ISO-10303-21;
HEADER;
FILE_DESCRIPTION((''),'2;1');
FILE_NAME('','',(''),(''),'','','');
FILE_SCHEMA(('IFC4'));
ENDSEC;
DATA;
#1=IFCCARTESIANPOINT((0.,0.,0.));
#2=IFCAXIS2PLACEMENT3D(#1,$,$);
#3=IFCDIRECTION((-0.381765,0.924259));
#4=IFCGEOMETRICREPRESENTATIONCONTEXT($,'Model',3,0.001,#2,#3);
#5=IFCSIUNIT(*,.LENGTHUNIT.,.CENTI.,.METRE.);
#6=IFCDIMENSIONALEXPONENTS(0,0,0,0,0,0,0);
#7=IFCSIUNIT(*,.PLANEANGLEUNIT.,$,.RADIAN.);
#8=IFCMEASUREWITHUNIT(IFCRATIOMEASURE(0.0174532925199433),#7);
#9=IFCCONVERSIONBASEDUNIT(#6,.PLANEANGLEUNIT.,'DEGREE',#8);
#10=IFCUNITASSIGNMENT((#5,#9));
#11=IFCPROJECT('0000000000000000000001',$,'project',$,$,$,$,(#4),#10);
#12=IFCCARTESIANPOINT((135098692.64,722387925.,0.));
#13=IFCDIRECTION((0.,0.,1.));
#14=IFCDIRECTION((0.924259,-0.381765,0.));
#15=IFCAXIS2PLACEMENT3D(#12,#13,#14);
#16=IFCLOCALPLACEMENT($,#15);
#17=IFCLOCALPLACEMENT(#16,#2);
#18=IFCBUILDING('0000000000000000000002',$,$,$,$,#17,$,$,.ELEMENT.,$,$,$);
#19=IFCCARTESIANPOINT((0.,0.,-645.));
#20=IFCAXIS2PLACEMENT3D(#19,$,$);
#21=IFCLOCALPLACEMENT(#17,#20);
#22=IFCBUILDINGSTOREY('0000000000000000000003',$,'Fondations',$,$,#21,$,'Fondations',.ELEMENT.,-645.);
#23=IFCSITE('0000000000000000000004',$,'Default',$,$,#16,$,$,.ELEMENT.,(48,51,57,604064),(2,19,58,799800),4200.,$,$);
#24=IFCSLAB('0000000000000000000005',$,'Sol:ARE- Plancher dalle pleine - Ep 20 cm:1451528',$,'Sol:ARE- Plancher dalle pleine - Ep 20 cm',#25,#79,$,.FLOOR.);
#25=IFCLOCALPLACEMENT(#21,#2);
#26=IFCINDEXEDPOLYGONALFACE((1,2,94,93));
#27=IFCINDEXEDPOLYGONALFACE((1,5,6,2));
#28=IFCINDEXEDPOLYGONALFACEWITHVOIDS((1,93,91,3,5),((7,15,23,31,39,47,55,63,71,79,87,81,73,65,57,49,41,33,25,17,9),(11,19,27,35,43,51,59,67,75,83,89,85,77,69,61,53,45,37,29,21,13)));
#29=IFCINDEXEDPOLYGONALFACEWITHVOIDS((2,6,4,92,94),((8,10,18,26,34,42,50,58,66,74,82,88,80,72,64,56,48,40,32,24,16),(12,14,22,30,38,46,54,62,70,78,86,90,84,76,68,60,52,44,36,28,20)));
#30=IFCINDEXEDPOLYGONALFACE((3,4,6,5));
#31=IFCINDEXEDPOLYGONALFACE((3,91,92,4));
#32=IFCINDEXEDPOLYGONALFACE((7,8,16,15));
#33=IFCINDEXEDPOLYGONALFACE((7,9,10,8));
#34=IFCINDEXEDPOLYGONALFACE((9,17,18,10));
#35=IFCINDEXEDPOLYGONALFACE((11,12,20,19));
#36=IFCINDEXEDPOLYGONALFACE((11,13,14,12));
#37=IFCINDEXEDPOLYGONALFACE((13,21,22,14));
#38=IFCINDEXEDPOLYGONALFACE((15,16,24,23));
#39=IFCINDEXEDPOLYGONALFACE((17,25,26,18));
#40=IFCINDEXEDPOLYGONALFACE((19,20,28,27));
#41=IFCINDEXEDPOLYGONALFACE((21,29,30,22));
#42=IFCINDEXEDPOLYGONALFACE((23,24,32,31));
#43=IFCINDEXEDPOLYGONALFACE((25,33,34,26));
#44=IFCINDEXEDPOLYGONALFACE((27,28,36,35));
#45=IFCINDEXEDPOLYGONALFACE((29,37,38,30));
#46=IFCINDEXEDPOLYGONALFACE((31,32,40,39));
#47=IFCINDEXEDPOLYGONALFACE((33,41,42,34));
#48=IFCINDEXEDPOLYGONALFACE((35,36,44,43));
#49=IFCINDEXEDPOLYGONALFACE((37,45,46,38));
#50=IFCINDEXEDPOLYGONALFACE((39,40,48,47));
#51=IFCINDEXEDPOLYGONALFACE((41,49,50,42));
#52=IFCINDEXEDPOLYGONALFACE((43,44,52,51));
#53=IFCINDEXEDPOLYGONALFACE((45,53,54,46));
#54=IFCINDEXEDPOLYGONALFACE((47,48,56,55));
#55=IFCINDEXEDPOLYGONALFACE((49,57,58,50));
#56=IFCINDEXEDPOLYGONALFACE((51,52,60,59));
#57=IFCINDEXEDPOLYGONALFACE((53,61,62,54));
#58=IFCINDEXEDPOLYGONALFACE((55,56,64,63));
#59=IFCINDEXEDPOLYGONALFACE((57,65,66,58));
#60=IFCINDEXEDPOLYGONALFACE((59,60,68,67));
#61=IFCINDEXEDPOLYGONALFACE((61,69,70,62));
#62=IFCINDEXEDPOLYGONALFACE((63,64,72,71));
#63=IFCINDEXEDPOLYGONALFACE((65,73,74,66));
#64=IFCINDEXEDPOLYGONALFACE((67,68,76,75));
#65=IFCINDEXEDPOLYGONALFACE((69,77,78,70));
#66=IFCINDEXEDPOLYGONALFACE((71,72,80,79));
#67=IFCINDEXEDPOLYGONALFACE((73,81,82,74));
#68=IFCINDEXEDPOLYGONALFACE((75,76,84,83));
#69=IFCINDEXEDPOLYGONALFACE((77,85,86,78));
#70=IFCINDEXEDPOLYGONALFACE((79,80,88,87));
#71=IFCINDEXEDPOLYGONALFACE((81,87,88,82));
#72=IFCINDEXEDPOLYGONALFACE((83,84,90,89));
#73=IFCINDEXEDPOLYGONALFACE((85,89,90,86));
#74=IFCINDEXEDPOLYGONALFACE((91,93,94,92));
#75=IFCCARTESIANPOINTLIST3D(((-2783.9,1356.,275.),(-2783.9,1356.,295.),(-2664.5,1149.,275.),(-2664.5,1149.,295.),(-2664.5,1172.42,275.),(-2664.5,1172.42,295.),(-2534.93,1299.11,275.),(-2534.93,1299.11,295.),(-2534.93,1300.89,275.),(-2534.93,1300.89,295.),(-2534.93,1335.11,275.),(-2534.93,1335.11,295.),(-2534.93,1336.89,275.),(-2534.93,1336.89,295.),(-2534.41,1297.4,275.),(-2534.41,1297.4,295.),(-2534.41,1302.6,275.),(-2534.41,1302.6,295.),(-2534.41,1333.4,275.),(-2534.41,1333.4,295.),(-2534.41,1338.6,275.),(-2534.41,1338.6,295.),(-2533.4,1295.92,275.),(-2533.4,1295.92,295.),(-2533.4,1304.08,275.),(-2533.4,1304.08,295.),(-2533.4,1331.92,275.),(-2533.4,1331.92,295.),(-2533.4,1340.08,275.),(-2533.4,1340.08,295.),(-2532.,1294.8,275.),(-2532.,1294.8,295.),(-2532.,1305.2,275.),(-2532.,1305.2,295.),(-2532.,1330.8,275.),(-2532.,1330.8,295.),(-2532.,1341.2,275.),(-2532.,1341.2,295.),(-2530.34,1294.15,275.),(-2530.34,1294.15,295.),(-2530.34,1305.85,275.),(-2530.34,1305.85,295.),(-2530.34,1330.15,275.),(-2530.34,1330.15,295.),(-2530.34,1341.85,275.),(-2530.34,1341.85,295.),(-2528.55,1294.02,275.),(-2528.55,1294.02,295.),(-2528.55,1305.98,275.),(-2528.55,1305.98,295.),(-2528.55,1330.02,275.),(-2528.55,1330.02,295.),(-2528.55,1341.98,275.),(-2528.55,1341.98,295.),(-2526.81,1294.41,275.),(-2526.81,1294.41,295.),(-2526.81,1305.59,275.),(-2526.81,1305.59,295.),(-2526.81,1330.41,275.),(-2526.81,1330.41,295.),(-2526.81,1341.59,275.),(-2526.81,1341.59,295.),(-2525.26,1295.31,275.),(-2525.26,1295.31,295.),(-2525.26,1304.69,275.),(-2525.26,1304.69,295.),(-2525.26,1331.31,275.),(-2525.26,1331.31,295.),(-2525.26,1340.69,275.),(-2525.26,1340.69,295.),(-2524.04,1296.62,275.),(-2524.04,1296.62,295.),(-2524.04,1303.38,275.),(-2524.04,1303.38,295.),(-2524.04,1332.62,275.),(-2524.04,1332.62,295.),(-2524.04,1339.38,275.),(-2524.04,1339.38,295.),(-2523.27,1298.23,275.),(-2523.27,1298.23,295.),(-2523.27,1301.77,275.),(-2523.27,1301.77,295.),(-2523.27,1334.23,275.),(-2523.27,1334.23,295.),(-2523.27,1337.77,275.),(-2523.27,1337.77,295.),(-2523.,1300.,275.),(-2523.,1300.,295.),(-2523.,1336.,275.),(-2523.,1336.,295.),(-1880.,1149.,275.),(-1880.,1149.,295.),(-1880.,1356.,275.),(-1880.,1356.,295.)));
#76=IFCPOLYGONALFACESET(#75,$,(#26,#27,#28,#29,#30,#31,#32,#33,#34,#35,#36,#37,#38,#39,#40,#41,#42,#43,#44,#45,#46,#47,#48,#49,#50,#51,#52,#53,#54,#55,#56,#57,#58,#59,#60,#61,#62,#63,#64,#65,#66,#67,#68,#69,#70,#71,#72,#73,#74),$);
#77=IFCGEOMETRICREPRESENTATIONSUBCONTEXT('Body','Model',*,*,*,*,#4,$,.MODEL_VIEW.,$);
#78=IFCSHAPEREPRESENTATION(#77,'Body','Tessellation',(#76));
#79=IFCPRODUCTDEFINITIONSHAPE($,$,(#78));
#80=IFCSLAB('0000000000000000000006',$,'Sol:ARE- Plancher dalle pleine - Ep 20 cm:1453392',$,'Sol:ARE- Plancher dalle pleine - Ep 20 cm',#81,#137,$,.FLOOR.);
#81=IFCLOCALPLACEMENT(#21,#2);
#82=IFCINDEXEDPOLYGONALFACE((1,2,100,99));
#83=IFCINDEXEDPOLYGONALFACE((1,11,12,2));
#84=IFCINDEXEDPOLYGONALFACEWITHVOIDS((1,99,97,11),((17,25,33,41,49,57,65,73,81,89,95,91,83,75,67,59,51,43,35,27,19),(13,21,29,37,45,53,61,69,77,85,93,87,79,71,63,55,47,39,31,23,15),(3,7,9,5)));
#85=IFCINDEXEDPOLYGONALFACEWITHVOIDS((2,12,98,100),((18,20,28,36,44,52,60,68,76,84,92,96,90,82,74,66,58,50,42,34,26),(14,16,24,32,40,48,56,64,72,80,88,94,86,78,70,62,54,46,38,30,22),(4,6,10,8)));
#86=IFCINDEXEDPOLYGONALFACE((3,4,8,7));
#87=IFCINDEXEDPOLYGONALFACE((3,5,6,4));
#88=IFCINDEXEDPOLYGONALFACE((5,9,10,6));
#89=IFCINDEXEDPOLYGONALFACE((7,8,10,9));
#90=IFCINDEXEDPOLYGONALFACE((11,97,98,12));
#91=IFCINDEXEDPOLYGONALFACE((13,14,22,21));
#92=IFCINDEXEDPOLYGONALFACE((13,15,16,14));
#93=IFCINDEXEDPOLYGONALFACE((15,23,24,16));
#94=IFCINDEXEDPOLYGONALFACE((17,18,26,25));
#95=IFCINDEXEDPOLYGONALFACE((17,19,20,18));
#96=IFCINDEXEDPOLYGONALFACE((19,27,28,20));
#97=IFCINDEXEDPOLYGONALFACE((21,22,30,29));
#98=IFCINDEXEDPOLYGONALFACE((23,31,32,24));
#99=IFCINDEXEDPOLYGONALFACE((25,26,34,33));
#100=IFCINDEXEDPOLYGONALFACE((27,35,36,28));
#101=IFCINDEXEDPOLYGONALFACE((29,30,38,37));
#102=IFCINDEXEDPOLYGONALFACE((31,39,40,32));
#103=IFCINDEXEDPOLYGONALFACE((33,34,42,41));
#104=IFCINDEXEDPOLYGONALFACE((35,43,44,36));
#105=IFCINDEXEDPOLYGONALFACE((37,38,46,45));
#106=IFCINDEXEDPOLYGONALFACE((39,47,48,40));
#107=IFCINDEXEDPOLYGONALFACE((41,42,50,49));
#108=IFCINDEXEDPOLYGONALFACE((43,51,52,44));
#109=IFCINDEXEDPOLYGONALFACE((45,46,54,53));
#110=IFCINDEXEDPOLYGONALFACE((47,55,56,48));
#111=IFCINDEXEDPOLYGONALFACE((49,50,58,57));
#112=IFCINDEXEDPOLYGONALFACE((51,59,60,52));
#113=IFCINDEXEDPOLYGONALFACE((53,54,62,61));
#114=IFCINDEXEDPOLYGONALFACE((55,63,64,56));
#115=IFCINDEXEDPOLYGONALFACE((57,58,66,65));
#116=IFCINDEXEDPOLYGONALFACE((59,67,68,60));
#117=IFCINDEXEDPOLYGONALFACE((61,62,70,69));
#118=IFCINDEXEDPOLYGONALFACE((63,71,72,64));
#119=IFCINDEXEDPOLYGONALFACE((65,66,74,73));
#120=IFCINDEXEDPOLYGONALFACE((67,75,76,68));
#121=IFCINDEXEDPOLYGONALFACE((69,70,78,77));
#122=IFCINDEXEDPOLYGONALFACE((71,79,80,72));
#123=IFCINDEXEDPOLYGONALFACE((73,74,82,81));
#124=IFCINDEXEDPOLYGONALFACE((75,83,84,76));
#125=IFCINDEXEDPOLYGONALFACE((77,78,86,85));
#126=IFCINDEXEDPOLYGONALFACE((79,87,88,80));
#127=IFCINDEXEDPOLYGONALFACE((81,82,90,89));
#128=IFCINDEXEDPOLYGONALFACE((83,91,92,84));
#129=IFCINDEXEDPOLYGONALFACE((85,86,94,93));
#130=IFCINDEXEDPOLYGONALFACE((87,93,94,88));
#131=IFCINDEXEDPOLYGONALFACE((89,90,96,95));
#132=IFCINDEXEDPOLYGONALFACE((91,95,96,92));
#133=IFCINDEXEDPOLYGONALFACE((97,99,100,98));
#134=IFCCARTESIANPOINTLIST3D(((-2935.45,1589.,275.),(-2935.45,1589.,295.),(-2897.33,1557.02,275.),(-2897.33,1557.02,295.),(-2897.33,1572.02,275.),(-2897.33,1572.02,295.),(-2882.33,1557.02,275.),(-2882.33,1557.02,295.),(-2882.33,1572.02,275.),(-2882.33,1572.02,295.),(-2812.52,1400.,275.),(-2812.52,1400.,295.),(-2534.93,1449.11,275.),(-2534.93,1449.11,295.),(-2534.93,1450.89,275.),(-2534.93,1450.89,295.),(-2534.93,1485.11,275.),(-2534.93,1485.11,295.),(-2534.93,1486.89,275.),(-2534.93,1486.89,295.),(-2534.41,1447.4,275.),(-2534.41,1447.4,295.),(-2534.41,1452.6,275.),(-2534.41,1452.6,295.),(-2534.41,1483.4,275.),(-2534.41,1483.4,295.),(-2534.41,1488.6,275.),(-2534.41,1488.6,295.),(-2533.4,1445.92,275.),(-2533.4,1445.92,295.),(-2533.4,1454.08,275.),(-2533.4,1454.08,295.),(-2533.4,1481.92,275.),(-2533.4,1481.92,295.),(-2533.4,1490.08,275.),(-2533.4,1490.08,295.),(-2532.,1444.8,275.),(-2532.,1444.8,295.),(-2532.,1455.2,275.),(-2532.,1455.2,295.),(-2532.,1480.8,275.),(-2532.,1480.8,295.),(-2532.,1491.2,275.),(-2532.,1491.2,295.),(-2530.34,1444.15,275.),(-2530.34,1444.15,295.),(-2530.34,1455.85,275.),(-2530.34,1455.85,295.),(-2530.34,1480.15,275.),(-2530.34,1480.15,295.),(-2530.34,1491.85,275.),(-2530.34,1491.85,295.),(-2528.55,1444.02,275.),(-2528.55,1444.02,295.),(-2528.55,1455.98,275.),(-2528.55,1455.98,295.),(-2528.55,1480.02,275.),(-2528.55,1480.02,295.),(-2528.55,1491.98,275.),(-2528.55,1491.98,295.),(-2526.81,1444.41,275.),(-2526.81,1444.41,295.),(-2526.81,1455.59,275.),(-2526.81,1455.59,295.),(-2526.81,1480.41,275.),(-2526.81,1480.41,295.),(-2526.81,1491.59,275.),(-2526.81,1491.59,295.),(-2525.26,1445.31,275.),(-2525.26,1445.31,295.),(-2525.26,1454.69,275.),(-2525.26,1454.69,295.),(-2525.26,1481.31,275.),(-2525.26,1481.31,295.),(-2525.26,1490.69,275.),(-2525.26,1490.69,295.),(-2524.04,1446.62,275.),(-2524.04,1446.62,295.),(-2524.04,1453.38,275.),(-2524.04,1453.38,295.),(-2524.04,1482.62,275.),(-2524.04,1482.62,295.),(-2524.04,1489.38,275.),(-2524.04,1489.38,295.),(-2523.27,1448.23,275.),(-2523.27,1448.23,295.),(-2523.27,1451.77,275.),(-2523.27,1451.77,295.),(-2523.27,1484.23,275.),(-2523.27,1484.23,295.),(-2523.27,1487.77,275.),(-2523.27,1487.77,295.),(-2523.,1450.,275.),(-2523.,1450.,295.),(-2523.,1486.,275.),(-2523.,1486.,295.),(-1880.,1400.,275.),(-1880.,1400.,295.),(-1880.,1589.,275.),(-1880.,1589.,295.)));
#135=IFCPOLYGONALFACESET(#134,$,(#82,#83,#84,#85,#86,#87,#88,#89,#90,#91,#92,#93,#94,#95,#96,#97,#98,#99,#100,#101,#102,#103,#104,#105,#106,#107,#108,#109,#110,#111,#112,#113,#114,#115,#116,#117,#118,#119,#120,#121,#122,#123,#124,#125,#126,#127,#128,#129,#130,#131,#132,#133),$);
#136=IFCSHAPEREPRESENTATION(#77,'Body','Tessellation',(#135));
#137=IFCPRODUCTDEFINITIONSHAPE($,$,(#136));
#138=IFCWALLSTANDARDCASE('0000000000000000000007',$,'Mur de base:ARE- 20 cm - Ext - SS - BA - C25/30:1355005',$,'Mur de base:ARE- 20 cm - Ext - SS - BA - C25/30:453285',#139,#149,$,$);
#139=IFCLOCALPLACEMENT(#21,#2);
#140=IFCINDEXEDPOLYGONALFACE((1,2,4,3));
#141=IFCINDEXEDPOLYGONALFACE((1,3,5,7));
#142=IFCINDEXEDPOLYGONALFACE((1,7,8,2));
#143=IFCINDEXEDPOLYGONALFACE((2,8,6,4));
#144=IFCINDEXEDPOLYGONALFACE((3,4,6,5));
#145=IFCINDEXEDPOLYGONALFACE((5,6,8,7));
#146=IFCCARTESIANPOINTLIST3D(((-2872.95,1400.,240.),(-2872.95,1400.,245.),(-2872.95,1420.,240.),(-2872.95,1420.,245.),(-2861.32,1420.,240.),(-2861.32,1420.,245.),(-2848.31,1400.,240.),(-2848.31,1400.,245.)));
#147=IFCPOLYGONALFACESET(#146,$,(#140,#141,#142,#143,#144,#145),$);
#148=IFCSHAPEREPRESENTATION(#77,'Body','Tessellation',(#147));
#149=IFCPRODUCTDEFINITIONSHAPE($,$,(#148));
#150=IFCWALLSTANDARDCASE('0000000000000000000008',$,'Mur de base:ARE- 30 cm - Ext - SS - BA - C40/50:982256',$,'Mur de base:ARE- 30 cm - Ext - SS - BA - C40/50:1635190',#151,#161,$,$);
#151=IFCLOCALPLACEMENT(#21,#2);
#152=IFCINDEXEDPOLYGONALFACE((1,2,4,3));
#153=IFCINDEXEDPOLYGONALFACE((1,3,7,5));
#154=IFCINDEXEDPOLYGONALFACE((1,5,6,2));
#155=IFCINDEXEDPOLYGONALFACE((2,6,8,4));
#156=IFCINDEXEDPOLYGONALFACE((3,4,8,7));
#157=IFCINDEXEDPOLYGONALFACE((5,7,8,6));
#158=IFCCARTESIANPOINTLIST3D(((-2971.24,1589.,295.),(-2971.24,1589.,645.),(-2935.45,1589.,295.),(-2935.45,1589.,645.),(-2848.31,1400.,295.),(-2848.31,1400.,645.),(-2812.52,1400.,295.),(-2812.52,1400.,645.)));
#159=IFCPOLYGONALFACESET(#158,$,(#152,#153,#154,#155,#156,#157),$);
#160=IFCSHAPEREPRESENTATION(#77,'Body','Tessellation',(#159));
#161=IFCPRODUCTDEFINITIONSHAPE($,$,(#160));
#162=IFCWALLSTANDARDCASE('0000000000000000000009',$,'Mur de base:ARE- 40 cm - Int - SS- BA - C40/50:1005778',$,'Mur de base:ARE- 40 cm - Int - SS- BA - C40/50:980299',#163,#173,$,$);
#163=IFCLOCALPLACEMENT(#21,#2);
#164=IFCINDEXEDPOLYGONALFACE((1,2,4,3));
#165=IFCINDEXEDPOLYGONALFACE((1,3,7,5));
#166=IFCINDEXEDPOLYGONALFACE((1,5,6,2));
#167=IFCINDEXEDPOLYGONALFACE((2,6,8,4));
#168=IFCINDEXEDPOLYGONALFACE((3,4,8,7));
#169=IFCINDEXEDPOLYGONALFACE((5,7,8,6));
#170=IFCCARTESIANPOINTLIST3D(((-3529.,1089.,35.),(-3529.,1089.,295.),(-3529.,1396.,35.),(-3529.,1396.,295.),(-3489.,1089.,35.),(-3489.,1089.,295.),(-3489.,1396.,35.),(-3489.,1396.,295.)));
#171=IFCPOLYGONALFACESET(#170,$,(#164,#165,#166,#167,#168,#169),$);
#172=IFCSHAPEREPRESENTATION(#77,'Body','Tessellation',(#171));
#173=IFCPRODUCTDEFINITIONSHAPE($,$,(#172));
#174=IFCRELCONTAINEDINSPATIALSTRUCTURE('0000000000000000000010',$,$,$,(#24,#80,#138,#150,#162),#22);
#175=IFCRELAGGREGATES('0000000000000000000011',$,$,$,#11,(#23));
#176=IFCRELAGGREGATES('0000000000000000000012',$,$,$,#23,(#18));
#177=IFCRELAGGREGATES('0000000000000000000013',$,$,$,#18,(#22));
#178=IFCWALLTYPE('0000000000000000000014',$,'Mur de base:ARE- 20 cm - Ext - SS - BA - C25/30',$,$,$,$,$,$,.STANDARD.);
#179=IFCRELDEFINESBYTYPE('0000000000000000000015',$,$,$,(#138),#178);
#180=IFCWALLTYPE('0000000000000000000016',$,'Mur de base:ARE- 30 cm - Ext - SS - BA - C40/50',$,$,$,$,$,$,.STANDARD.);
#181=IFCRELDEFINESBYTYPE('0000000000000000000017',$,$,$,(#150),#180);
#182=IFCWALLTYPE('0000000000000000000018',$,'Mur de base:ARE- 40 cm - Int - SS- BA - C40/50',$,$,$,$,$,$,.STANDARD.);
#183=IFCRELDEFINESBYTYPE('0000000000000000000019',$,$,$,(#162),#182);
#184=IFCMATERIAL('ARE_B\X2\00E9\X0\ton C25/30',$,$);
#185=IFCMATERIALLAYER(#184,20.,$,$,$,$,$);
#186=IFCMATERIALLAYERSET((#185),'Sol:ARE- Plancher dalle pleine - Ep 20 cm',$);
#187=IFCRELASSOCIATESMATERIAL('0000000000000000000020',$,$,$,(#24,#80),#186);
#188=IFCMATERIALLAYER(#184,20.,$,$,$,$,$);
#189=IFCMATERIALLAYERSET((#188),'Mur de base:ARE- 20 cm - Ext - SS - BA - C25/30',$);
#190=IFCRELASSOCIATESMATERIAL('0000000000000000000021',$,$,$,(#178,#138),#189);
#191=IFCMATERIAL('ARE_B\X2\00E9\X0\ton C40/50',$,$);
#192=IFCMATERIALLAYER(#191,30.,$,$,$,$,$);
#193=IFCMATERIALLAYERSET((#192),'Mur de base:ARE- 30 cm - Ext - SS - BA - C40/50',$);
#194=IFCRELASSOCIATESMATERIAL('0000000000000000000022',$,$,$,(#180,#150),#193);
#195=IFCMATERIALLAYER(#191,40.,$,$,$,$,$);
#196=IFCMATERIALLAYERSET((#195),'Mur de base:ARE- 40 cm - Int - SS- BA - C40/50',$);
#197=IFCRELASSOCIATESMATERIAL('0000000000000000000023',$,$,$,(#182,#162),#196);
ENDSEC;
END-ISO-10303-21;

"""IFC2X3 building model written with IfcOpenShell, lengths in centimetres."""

from ifc_helpers import new_model, entity, si_unit, converted_unit, direction, frame, frame_2d, origin, origin_2d_with_axis, place, context, subcontext, project, spatial, polyline, rectangle, circle, outline, extrude, material, layer, layer_set, layer_usage, type_object, element, save


model = new_model("IFC2X3")

# Units and contexts
model_context = context("Model", 3, precision=0.001, world=origin(), true_north=direction((-0.381765, 0.924259)))
body_context = subcontext(model_context, "Body", "Model", "MODEL_VIEW")
ifc_project = project(units=[si_unit("LENGTHUNIT", "METRE", prefix="CENTI"), converted_unit("PLANEANGLEUNIT", "DEGREE", entity("IfcRatioMeasure", 0.0174532925199433), si_unit("PLANEANGLEUNIT", "RADIAN"), dimensions=[0, 0, 0, 0, 0, 0, 0])], contexts=[model_context])

# Site, building, storey
site_placement = place(None, frame((135098692.64, 722387925.0, 0.0), z_axis=(0.0, 0.0, 1.0), x_axis=(0.924259, -0.381765, 0.0)))
site = spatial("IfcSite", under=ifc_project, at=site_placement, Name="Default", CompositionType="ELEMENT", RefLatitude=(48, 51, 57, 604064), RefLongitude=(2, 19, 58, 799800), RefElevation=4200.0)
building_placement = place(site_placement, origin())
building = spatial("IfcBuilding", under=site, at=building_placement, CompositionType="ELEMENT")
storey_placement = place(building_placement, frame((0.0, 0.0, -645.0)))
storey = spatial("IfcBuildingStorey", under=building, at=storey_placement, Name="Fondations", LongName="Fondations", CompositionType="ELEMENT", Elevation=-645.0)

# Slabs, openings
ifc_material_1 = material(Name="ARE_Béton C25/30")
ifc_layer_1 = layer(ifc_material_1, 20.0)
ifc_layer_set_1 = layer_set([ifc_layer_1], Name="Sol:ARE- Plancher dalle pleine - Ep 20 cm")
ifc_layer_usage_1 = layer_usage(ifc_layer_set_1, "AXIS3", "POSITIVE", 0.0)
slab_1_placement = place(storey_placement, frame((-2783.9, 1149.0, 275.0)))
slab_1 = element("IfcSlab", 1, at=slab_1_placement, inside=storey, material=ifc_layer_usage_1, Name="Sol:ARE- Plancher dalle pleine - Ep 20 cm:1451528", ObjectType="Sol:ARE- Plancher dalle pleine - Ep 20 cm", PredefinedType="FLOOR", context=body_context, shape_type="SweptSolid", body=[
    extrude(outline(polyline([(-451.95, -103.5), (332.55, -103.5), (332.55, -80.08), (451.95, 103.5), (-451.95, 103.5), (-451.95, -103.5)])), frame((451.95, 103.5, 20.0), z_axis=(0.0, 0.0, -1.0), x_axis=(-1.0, 0.0, 0.0)), (0.0, 0.0, 1.0), 20.0),
])
opening_1_placement = place(slab_1_placement, origin())
element("IfcOpeningElement", 2, at=opening_1_placement, cuts=slab_1, ObjectType="Opening", context=body_context, shape_type="SweptSolid", body=[
    extrude(circle(Radius=6.0, at=origin_2d_with_axis()), frame((254.9, 187.0, 0.0)), (0.0, 0.0, 1.0), 20.0),
])
opening_2_placement = place(slab_1_placement, origin())
element("IfcOpeningElement", 3, at=opening_2_placement, cuts=slab_1, ObjectType="Opening", context=body_context, shape_type="SweptSolid", body=[
    extrude(circle(Radius=6.0, at=origin_2d_with_axis()), frame((254.9, 151.0, 0.0)), (0.0, 0.0, 1.0), 20.0),
])
ifc_layer_usage_2 = layer_usage(ifc_layer_set_1, "AXIS3", "POSITIVE", 0.0)
slab_2_placement = place(storey_placement, frame((-2935.45, 1400.0, 275.0)))
slab_2 = element("IfcSlab", 4, at=slab_2_placement, inside=storey, material=ifc_layer_usage_2, Name="Sol:ARE- Plancher dalle pleine - Ep 20 cm:1453392", ObjectType="Sol:ARE- Plancher dalle pleine - Ep 20 cm", PredefinedType="FLOOR", context=body_context, shape_type="SweptSolid", body=[
    extrude(outline(polyline([(-527.72, -94.5), (404.8, -94.5), (527.72, 94.5), (-527.72, 94.5), (-527.72, -94.5)])), frame((527.72, 94.5, 20.0), z_axis=(0.0, 0.0, -1.0), x_axis=(-1.0, 0.0, 0.0)), (0.0, 0.0, 1.0), 20.0),
])
opening_3_placement = place(slab_2_placement, origin())
element("IfcOpeningElement", 5, at=opening_3_placement, cuts=slab_2, ObjectType="Opening", context=body_context, shape_type="SweptSolid", body=[
    extrude(rectangle(XDim=15.0, YDim=15.0, at=origin_2d_with_axis()), frame((45.62, 164.52, -5.0), z_axis=(0.0, 0.0, 1.0), x_axis=(-1.0, 0.0, 0.0)), (0.0, 0.0, 1.0), 25.0),
])
opening_4_placement = place(slab_2_placement, origin())
element("IfcOpeningElement", 6, at=opening_4_placement, cuts=slab_2, ObjectType="Opening", context=body_context, shape_type="SweptSolid", body=[
    extrude(circle(Radius=6.0, at=origin_2d_with_axis()), frame((406.45, 50.0, 0.0)), (0.0, 0.0, 1.0), 20.0),
])
opening_5_placement = place(slab_2_placement, origin())
element("IfcOpeningElement", 7, at=opening_5_placement, cuts=slab_2, ObjectType="Opening", context=body_context, shape_type="SweptSolid", body=[
    extrude(circle(Radius=6.0, at=origin_2d_with_axis()), frame((406.45, 86.0, 0.0)), (0.0, 0.0, 1.0), 20.0),
])

# Walls
ifc_layer_2 = layer(ifc_material_1, 20.0)
ifc_layer_set_2 = layer_set([ifc_layer_2], Name="Mur de base:ARE- 20 cm - Ext - SS - BA - C25/30")
ifc_layer_usage_3 = layer_usage(ifc_layer_set_2, "AXIS2", "NEGATIVE", 10.0)
wall_type_1 = type_object("IfcWallType", Name="Mur de base:ARE- 20 cm - Ext - SS - BA - C25/30", PredefinedType="STANDARD", material=ifc_layer_set_2)
wall_1_placement = place(storey_placement, frame((-2872.95, 1410.0, 240.0)))
element("IfcWallStandardCase", 8, at=wall_1_placement, inside=storey, type_object=wall_type_1, material=ifc_layer_usage_3, Name="Mur de base:ARE- 20 cm - Ext - SS - BA - C25/30:1355005", ObjectType="Mur de base:ARE- 20 cm - Ext - SS - BA - C25/30:453285", context=body_context, shape_type="SweptSolid", body=[
    extrude(outline(polyline([(24.65, -10.0), (11.64, 10.0), (0.0, 10.0), (0.0, -10.0), (24.65, -10.0)])), origin(), (0.0, 0.0, 1.0), 5.0),
])
ifc_material_2 = material(Name="ARE_Béton C40/50")
ifc_layer_3 = layer(ifc_material_2, 30.0)
ifc_layer_set_3 = layer_set([ifc_layer_3], Name="Mur de base:ARE- 30 cm - Ext - SS - BA - C40/50")
ifc_layer_usage_4 = layer_usage(ifc_layer_set_3, "AXIS2", "NEGATIVE", 15.0)
wall_type_2 = type_object("IfcWallType", Name="Mur de base:ARE- 30 cm - Ext - SS - BA - C40/50", PredefinedType="STANDARD", material=ifc_layer_set_3)
wall_2_placement = place(storey_placement, frame((-2958.66, 1597.18, 295.0), z_axis=(0.0, 0.0, 1.0), x_axis=(0.545236, -0.838282, 0.0)))
element("IfcWallStandardCase", 9, at=wall_2_placement, inside=storey, type_object=wall_type_2, material=ifc_layer_usage_4, Name="Mur de base:ARE- 30 cm - Ext - SS - BA - C40/50:982256", ObjectType="Mur de base:ARE- 30 cm - Ext - SS - BA - C40/50:1635190", context=body_context, shape_type="SweptSolid", body=[
    extrude(outline(polyline([(225.46, -15.0), (244.97, 15.0), (19.51, 15.0), (0.0, -15.0), (225.46, -15.0)])), origin(), (0.0, 0.0, 1.0), 350.0),
])
ifc_layer_4 = layer(ifc_material_2, 40.0)
ifc_layer_set_4 = layer_set([ifc_layer_4], Name="Mur de base:ARE- 40 cm - Int - SS- BA - C40/50")
ifc_layer_usage_5 = layer_usage(ifc_layer_set_4, "AXIS2", "NEGATIVE", 20.0)
wall_type_3 = type_object("IfcWallType", Name="Mur de base:ARE- 40 cm - Int - SS- BA - C40/50", PredefinedType="STANDARD", material=ifc_layer_set_4)
wall_3_placement = place(storey_placement, frame((-3509.0, 1089.0, 35.0), z_axis=(0.0, 0.0, 1.0), x_axis=(0.0, 1.0, 0.0)))
element("IfcWallStandardCase", 10, at=wall_3_placement, inside=storey, type_object=wall_type_3, material=ifc_layer_usage_5, Name="Mur de base:ARE- 40 cm - Int - SS- BA - C40/50:1005778", ObjectType="Mur de base:ARE- 40 cm - Int - SS- BA - C40/50:980299", context=body_context, shape_type="SweptSolid", body=[
    extrude(rectangle(XDim=307.0, YDim=40.0, at=frame_2d((153.5, 0.0), x_axis=(-1.0, 0.0))), origin(), (0.0, 0.0, 1.0), 260.0),
])

save(model, "model.ifc")
